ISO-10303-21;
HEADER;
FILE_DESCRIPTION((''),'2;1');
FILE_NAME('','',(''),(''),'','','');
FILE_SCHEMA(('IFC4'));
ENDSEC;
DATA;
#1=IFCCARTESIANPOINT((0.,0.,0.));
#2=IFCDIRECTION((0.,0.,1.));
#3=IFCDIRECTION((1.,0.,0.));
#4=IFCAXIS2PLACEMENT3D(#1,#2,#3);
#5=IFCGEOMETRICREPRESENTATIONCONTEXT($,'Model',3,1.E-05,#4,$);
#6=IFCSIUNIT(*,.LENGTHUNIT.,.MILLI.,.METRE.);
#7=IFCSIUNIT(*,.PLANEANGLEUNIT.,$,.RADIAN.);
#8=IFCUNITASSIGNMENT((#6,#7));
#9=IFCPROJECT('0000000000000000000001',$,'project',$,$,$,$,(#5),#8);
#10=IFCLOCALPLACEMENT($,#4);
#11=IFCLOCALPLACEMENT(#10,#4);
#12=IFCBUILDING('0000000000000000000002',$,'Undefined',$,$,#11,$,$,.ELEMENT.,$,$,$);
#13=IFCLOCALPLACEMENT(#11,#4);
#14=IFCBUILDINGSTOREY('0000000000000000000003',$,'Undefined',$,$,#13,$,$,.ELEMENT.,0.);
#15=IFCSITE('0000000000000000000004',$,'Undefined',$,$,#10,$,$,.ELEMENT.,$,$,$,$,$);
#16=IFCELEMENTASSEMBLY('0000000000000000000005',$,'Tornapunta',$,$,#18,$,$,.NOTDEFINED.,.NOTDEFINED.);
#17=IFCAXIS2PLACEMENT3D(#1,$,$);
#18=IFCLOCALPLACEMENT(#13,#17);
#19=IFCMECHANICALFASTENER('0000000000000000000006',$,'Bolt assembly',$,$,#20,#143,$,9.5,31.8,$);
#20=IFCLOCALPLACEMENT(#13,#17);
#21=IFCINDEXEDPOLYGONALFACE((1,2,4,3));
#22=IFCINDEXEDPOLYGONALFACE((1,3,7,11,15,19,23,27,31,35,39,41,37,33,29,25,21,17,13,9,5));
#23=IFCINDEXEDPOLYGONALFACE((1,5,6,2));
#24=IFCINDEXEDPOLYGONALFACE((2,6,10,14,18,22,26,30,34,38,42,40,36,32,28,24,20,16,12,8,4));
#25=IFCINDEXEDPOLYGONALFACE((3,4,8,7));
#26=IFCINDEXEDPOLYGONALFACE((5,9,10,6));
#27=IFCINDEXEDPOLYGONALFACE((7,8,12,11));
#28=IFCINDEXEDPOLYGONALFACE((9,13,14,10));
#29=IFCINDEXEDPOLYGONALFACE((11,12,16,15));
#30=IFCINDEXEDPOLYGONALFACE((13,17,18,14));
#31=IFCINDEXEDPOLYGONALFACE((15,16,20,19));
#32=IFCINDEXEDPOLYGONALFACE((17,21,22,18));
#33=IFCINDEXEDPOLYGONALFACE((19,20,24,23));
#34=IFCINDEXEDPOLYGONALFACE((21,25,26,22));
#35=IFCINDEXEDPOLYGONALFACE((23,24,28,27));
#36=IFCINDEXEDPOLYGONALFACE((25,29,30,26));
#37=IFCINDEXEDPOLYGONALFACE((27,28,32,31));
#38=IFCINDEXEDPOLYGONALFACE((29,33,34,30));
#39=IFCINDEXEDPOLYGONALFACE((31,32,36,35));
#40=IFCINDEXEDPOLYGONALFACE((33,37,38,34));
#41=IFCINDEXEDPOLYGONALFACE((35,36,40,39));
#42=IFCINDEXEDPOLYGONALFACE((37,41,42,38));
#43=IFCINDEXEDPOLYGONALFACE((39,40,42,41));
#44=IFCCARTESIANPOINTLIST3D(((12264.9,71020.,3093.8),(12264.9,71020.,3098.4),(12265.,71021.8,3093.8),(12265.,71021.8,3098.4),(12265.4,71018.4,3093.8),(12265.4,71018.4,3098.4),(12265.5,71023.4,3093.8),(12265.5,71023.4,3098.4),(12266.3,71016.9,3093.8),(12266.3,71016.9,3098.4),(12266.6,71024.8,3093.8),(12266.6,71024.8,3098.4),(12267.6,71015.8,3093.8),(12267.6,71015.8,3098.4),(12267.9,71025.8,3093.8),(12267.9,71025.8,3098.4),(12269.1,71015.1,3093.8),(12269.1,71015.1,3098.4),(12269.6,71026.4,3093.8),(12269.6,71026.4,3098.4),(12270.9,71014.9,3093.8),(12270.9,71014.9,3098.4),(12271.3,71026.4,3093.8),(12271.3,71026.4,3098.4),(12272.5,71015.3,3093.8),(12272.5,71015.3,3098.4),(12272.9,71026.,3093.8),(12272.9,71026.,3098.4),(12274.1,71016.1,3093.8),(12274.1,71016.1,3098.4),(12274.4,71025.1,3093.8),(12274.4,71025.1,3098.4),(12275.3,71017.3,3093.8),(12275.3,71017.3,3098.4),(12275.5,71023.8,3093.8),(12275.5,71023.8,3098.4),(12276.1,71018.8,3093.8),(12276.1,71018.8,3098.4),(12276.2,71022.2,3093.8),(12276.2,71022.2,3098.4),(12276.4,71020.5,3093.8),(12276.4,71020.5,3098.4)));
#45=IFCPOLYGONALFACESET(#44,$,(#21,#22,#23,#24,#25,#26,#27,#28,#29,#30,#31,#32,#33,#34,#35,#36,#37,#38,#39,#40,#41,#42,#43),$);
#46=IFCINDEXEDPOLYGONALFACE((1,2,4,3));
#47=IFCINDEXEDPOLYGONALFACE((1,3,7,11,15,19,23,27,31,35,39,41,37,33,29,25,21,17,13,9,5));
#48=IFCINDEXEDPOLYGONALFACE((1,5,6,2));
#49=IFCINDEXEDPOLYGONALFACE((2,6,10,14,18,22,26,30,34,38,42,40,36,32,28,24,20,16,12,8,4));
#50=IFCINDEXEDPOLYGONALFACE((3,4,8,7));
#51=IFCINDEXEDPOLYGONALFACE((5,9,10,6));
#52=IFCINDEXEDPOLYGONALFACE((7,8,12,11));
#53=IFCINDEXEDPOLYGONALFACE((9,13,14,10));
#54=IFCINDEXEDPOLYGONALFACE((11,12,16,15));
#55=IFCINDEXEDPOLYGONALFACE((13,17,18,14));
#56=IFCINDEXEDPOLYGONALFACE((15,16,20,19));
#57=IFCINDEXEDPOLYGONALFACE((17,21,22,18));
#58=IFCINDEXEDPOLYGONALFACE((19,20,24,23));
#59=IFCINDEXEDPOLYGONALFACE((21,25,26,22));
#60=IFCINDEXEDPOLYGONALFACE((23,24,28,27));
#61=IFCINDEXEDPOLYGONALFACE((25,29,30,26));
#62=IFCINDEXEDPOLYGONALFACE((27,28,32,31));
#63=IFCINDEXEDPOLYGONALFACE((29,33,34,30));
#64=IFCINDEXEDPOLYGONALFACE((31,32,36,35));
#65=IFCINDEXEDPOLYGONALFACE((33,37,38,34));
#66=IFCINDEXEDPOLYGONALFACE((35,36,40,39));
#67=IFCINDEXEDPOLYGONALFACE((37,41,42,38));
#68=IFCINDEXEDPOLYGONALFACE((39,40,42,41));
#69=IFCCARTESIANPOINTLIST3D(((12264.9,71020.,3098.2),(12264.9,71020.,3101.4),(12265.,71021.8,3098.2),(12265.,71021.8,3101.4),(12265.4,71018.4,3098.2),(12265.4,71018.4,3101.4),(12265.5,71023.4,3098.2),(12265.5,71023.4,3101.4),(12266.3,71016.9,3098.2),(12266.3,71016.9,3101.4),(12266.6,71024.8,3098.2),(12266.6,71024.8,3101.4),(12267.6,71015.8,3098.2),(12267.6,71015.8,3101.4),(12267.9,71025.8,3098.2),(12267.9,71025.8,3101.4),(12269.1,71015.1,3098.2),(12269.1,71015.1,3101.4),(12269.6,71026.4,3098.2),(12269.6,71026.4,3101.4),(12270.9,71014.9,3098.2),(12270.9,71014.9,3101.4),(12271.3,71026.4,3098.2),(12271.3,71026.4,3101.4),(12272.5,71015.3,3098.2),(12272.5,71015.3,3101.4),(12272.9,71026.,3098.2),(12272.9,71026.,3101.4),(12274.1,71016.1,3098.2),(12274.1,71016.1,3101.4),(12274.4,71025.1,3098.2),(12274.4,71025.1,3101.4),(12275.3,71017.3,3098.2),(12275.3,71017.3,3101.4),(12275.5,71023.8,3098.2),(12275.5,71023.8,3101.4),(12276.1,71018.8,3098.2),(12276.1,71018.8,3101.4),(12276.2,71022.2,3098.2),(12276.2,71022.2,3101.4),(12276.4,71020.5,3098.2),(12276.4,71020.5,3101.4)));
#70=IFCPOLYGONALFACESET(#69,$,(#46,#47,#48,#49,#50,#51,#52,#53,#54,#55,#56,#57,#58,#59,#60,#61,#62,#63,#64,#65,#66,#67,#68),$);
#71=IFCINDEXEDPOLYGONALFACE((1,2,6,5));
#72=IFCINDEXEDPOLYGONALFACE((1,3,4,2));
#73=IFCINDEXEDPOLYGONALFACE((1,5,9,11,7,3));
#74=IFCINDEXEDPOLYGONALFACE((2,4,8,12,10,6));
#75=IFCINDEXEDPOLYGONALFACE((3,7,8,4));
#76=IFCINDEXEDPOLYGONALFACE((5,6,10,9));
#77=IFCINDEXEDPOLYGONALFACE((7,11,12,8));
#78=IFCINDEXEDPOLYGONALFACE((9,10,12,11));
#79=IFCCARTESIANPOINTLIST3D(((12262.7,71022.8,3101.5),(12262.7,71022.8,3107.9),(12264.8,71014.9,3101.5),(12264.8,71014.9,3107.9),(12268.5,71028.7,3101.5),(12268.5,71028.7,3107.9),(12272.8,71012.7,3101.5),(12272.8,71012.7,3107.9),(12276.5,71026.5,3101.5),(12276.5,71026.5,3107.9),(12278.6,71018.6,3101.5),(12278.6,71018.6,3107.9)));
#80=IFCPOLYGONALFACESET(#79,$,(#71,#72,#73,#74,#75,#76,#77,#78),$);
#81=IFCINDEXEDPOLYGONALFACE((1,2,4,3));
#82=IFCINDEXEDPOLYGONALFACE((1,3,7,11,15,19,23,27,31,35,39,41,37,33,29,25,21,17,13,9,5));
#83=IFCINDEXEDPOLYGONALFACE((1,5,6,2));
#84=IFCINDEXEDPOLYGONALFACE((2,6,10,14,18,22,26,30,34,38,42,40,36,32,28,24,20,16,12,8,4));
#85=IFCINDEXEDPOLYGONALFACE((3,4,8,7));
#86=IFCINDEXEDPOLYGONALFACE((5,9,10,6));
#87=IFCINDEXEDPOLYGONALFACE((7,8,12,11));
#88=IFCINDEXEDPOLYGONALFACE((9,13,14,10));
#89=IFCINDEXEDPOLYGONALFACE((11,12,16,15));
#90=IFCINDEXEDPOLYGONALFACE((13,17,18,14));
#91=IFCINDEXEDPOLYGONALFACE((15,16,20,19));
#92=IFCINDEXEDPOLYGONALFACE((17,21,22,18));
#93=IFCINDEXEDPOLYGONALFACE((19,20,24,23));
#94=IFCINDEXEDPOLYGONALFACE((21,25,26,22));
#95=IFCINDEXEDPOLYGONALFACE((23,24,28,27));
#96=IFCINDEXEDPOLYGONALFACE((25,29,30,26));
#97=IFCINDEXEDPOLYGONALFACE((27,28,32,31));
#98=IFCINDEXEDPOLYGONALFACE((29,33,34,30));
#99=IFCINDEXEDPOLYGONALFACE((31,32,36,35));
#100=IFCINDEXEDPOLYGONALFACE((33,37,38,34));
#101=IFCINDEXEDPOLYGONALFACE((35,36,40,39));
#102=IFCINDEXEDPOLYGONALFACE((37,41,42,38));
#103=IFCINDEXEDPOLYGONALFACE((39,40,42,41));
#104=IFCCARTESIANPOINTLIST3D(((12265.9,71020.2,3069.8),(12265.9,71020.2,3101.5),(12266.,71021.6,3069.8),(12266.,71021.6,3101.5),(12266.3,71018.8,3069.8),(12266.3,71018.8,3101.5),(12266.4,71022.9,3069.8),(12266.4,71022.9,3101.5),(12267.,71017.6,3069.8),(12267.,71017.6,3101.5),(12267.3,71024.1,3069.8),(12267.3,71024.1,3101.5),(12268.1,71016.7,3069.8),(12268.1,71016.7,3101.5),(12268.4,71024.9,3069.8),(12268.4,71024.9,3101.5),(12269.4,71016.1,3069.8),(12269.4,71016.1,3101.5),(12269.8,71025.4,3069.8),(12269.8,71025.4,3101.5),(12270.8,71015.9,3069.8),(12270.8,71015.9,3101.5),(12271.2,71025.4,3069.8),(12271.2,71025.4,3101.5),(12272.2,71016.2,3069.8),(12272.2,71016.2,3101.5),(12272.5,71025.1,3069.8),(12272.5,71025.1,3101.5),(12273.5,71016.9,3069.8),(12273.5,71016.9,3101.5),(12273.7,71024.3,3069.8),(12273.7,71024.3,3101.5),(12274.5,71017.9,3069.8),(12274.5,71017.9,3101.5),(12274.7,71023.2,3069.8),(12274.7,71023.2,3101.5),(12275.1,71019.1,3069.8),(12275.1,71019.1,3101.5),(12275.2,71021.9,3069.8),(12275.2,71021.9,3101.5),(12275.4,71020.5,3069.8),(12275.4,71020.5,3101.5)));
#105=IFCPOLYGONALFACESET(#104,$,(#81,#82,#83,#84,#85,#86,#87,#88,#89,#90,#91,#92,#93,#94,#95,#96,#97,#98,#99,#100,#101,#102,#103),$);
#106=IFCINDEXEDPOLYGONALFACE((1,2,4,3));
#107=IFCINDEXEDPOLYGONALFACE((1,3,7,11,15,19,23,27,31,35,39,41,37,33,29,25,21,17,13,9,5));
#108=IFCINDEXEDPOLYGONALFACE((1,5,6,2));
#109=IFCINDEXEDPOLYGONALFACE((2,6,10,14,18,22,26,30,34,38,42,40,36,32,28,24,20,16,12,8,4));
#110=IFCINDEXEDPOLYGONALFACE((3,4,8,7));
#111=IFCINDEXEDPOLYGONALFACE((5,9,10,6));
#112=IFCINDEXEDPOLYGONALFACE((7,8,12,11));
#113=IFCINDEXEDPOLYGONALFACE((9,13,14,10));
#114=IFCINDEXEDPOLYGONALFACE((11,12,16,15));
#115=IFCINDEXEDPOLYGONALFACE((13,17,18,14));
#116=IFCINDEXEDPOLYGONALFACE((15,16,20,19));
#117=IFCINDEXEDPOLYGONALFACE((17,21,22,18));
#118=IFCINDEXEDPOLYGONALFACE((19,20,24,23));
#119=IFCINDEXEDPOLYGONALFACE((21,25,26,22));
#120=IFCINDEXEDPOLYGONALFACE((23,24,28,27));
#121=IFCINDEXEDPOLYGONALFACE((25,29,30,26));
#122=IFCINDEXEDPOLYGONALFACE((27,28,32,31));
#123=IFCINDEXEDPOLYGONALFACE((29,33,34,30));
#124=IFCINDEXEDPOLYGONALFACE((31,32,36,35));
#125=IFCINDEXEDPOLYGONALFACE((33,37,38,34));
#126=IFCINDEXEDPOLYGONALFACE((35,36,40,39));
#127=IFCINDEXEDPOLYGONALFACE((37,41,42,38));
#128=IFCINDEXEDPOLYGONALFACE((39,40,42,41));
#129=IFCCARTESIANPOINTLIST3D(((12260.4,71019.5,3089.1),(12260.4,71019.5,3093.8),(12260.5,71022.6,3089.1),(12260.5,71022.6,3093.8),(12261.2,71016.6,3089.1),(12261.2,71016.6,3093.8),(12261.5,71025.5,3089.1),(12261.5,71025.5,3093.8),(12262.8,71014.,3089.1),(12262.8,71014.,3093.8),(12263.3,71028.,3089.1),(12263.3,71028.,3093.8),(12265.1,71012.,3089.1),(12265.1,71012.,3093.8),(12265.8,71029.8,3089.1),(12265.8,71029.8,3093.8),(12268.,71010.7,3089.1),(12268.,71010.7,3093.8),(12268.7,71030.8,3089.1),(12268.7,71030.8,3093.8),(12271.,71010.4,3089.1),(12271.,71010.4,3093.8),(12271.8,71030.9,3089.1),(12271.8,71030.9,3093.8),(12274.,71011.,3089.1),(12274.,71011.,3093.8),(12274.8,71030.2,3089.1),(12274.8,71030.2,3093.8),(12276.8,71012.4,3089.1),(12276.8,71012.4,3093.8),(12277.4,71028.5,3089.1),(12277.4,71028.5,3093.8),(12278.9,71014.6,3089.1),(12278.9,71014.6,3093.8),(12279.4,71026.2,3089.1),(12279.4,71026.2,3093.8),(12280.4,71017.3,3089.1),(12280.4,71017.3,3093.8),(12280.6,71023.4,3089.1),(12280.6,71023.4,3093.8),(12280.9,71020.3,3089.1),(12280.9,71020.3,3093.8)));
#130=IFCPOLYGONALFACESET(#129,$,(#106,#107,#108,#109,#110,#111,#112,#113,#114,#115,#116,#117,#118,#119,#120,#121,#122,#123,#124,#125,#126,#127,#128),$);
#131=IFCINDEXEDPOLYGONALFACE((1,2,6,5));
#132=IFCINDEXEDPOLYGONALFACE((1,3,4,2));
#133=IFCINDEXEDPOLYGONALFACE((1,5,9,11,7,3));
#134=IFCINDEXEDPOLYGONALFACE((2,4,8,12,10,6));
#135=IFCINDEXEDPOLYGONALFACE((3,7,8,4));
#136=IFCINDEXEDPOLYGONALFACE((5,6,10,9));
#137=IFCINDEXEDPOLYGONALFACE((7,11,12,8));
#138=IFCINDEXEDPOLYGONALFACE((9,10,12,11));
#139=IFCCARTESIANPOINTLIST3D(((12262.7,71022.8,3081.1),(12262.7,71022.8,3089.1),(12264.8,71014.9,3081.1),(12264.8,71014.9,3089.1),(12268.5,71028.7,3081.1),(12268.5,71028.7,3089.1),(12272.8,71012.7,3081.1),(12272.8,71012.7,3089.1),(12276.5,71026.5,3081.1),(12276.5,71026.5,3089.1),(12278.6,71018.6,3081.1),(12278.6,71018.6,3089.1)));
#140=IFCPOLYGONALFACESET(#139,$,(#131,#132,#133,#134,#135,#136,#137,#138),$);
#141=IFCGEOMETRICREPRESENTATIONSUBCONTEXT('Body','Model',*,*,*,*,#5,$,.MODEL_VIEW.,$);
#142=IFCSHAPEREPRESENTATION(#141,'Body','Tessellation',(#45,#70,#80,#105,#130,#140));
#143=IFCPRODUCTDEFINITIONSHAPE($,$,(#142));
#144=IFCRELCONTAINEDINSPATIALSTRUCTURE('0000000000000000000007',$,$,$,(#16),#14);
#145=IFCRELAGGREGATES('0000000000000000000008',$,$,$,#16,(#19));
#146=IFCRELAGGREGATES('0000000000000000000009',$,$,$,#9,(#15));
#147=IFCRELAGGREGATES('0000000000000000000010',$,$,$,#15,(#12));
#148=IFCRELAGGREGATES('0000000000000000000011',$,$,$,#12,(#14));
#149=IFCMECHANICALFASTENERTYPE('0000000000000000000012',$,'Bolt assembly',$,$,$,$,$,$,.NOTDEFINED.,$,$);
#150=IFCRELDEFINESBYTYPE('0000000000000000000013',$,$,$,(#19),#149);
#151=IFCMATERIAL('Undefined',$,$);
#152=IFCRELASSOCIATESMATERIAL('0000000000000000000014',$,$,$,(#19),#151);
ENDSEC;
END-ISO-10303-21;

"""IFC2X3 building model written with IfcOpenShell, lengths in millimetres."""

from ifc_helpers import new_model, si_unit, frame, origin_with_axes, origin_2d_with_axis, place, context, subcontext, project, spatial, polyline, circle, outline, extrude, source, transform, mapped, material, type_object, element, aggregate, save


model = new_model("IFC2X3")

# Units and contexts
model_context = context("Model", 3, precision=1e-05, world=origin_with_axes())
body_context = subcontext(model_context, "Body", "Model", "MODEL_VIEW")
ifc_project = project(units=[si_unit("LENGTHUNIT", "METRE", prefix="MILLI"), si_unit("PLANEANGLEUNIT", "RADIAN")], contexts=[model_context])

# Site, building, storey
site_placement = place(None, origin_with_axes())
site = spatial("IfcSite", under=ifc_project, at=site_placement, Name="Undefined", CompositionType="ELEMENT")
building_placement = place(site_placement, origin_with_axes())
building = spatial("IfcBuilding", under=site, at=building_placement, Name="Undefined", CompositionType="ELEMENT")
storey_placement = place(building_placement, origin_with_axes())
storey = spatial("IfcBuildingStorey", under=building, at=storey_placement, Name="Undefined", CompositionType="ELEMENT", Elevation=0.0)

# Element assembly
assembly_1_placement = place(storey_placement, origin_with_axes())
assembly_1 = element("IfcElementAssembly", 1, at=assembly_1_placement, inside=storey, Name="Tornapunta", AssemblyPlace="NOTDEFINED", PredefinedType="NOTDEFINED")

# Mechanical fastener
ifc_material_1 = material(Name="Undefined")
mechanical_fastener_type = type_object("IfcMechanicalFastenerType", Name="Bolt assembly")
shared_shape_1 = source(origin_with_axes(), body_context, "Body", "SweptSolid", [
    extrude(circle(Radius=5.8, at=origin_2d_with_axis()), frame((0.0, -0.1, 0.0), z_axis=(0.0, 1.0, 0.0), x_axis=(1.0, 0.0, 0.0)), (0.0, 0.0, 1.0), 4.6),
    extrude(circle(Radius=5.8, at=origin_2d_with_axis()), frame((0.0, -3.1, 0.0), z_axis=(0.0, 1.0, 0.0), x_axis=(1.0, 0.0, 0.0)), (0.0, 0.0, 1.0), 3.2),
    extrude(outline(polyline([(7.1, -4.1), (7.1, 4.1), (0.0, 8.2), (-7.1, 4.1), (-7.1, -4.1), (0.0, -8.2), (7.1, -4.1)])), frame((0.0, -9.5, 0.0), z_axis=(0.0, 1.0, 0.0), x_axis=(1.0, 0.0, 0.0)), (0.0, 0.0, 1.0), 6.3),
    extrude(circle(Radius=4.8, at=origin_2d_with_axis()), frame((0.0, -3.2, 0.0), z_axis=(0.0, 1.0, 0.0), x_axis=(1.0, 0.0, 0.0)), (0.0, 0.0, 1.0), 31.8),
    extrude(circle(Radius=10.3, at=origin_2d_with_axis()), frame((0.0, 4.5, 0.0), z_axis=(0.0, 1.0, 0.0), x_axis=(1.0, 0.0, 0.0)), (0.0, 0.0, 1.0), 4.8),
    extrude(outline(polyline([(7.1, -4.1), (7.1, 4.1), (0.0, 8.2), (-7.1, 4.1), (-7.1, -4.1), (0.0, -8.2), (7.1, -4.1)])), frame((0.0, 9.3, 0.0), z_axis=(0.0, 1.0, 0.0), x_axis=(1.0, 0.0, 0.0)), (0.0, 0.0, 1.0), 7.9),
])
mechanical_fastener_1_placement = place(assembly_1_placement, frame((12270.6, 71020.7, 3098.3), z_axis=(-0.707107, -0.707107, 0.000016), x_axis=(-0.707107, 0.707107, -0.000016)))
mechanical_fastener_1 = element("IfcMechanicalFastener", 2, at=mechanical_fastener_1_placement, type_object=mechanical_fastener_type, material=ifc_material_1, Name="Bolt assembly", NominalDiameter=9.5, NominalLength=31.8, context=body_context, shape_type="MappedRepresentation", body=[
    mapped(shared_shape_1, transform((0.0, 0.0, 0.0))),
])
aggregate(assembly_1, [mechanical_fastener_1])

save(model, "model.ifc")
